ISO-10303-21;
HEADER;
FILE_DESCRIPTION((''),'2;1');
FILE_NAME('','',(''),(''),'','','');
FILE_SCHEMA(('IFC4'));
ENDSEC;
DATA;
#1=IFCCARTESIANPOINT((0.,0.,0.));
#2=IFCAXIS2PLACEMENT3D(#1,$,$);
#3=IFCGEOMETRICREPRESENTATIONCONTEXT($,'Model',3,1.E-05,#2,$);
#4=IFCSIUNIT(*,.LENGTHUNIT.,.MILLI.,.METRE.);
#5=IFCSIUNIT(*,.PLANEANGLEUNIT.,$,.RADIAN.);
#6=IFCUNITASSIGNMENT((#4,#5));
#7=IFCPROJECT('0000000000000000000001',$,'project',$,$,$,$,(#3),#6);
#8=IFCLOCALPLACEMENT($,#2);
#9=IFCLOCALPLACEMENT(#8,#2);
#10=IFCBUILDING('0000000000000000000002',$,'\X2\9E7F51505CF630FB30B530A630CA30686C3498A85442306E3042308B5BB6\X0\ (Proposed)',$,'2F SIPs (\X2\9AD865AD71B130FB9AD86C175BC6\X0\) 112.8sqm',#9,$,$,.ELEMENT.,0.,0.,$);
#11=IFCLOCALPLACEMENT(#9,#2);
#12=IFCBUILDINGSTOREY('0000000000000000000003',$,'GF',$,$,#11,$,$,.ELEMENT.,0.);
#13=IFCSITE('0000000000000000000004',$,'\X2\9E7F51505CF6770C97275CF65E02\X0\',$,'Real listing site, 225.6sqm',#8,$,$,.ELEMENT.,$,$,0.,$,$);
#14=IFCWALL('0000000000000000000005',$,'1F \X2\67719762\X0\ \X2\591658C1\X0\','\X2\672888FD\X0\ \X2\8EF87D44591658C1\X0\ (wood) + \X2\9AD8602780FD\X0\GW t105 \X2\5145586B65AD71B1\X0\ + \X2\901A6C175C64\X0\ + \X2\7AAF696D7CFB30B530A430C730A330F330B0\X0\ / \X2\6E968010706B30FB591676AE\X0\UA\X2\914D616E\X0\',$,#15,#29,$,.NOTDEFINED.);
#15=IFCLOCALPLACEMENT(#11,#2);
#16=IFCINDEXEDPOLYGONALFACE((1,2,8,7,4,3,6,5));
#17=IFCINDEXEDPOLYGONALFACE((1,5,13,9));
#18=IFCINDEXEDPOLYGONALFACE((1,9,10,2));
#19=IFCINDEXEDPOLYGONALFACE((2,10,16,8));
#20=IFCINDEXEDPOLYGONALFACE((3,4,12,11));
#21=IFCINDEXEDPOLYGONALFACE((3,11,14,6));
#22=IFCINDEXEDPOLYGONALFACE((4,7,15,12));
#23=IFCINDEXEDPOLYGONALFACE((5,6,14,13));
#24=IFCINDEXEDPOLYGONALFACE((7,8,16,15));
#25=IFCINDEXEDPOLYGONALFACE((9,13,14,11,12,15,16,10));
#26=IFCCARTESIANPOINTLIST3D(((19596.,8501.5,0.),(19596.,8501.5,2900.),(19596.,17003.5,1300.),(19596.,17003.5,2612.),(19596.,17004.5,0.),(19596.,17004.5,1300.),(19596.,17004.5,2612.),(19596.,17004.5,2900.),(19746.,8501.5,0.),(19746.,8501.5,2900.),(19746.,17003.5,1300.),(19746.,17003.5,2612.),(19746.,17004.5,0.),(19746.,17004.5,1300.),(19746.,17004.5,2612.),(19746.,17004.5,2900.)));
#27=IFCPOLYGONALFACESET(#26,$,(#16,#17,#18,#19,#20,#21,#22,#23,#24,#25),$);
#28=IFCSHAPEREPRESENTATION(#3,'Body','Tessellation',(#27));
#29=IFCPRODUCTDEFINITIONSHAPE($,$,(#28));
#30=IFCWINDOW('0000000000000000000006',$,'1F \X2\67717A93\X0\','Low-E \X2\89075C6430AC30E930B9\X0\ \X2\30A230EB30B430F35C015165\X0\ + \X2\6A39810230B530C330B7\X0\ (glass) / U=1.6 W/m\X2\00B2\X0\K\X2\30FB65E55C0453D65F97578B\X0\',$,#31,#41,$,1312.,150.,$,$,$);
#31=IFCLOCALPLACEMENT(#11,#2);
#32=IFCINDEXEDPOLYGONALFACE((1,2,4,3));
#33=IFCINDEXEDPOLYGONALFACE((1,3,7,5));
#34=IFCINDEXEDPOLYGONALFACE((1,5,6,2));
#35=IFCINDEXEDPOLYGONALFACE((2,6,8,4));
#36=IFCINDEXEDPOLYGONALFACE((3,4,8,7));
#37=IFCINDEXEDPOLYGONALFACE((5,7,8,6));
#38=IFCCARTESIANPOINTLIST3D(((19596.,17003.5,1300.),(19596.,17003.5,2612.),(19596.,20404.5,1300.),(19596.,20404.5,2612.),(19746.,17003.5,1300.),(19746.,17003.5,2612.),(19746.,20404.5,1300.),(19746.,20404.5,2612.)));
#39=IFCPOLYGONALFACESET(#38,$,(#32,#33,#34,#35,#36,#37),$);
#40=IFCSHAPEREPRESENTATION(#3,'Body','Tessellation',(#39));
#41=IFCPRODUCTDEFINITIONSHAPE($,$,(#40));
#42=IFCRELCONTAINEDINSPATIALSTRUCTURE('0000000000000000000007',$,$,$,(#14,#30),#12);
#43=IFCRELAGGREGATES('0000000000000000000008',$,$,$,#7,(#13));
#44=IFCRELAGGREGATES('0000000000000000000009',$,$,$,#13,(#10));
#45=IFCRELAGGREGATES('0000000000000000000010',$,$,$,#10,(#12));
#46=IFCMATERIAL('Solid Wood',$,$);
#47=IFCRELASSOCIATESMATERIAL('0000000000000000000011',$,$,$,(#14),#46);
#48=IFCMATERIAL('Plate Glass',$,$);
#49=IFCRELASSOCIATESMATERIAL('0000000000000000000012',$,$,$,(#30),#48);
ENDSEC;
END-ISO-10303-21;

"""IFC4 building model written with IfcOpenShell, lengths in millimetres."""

from ifc_helpers import new_model, si_unit, frame, frame_2d, origin, place, context, project, spatial, rectangle, extrude, material, element, fill, save


model = new_model("IFC4")

# Units and contexts
model_context = context("Model", 3, precision=1e-05, world=origin())
ifc_project = project(units=[si_unit("LENGTHUNIT", "METRE", prefix="MILLI"), si_unit("PLANEANGLEUNIT", "RADIAN")], contexts=[model_context])

# Site, building, storey
site_placement = place(None, origin())
site = spatial("IfcSite", under=ifc_project, at=site_placement, Name="鹿児島県霧島市", ObjectType="Real listing site, 225.6sqm", CompositionType="ELEMENT", RefElevation=0.0)
building_placement = place(site_placement, origin())
building = spatial("IfcBuilding", under=site, at=building_placement, Name="鹿児島・サウナと水風呂のある家 (Proposed)", ObjectType="2F SIPs (高断熱・高気密) 112.8sqm", CompositionType="ELEMENT", ElevationOfRefHeight=0.0, ElevationOfTerrain=0.0)
storey_placement = place(building_placement, origin())
storey = spatial("IfcBuildingStorey", under=building, at=storey_placement, Name="GF", CompositionType="ELEMENT", Elevation=0.0)

# Wall, opening, window
ifc_material_1 = material(Name="Solid Wood")
wall_1_placement = place(storey_placement, frame((9798.0, 4251.0, 0.0)))
wall_1 = element("IfcWall", 1, at=wall_1_placement, inside=storey, material=ifc_material_1, Name="1F 東面 外壁", Description="木製 軸組外壁 (wood) + 高性能GW t105 充填断熱 + 通気層 + 窯業系サイディング / 準耐火・外皮UA配慮", PredefinedType="NOTDEFINED", context=model_context, shape_type="SweptSolid", body=[
    extrude(rectangle(XDim=150.0, YDim=8503.0, at=frame_2d((75.0, 4251.0))), frame((9798.0, 4251.0, 0.0)), (0.0, 0.0, 1.0), 2900.0),
])
opening_1_placement = place(storey_placement, frame((9798.0, 8502.0, 650.0)))
opening_1 = element("IfcOpeningElement", 2, at=opening_1_placement, cuts=wall_1, PredefinedType="NOTDEFINED", context=model_context, shape_type="SweptSolid", body=[
    extrude(rectangle(XDim=150.0, YDim=3401.0, at=frame_2d((75.0, 1700.0))), frame((9798.0, 8502.0, 650.0)), (0.0, 0.0, 1.0), 1312.0),
])
ifc_material_2 = material(Name="Plate Glass")
window_1_placement = place(storey_placement, frame((9798.0, 8502.0, 650.0)))
window_1 = element("IfcWindow", 3, at=window_1_placement, inside=storey, material=ifc_material_2, Name="1F 東窓", Description="Low-E 複層ガラス アルゴン封入 + 樹脂サッシ (glass) / U=1.6 W/m²K・日射取得型", OverallHeight=1312.0, OverallWidth=150.0, context=model_context, shape_type="SweptSolid", body=[
    extrude(rectangle(XDim=150.0, YDim=3401.0, at=frame_2d((75.0, 1700.0))), frame((9798.0, 8502.0, 650.0)), (0.0, 0.0, 1.0), 1312.0),
])
fill(opening_1, window_1)

save(model, "model.ifc")
